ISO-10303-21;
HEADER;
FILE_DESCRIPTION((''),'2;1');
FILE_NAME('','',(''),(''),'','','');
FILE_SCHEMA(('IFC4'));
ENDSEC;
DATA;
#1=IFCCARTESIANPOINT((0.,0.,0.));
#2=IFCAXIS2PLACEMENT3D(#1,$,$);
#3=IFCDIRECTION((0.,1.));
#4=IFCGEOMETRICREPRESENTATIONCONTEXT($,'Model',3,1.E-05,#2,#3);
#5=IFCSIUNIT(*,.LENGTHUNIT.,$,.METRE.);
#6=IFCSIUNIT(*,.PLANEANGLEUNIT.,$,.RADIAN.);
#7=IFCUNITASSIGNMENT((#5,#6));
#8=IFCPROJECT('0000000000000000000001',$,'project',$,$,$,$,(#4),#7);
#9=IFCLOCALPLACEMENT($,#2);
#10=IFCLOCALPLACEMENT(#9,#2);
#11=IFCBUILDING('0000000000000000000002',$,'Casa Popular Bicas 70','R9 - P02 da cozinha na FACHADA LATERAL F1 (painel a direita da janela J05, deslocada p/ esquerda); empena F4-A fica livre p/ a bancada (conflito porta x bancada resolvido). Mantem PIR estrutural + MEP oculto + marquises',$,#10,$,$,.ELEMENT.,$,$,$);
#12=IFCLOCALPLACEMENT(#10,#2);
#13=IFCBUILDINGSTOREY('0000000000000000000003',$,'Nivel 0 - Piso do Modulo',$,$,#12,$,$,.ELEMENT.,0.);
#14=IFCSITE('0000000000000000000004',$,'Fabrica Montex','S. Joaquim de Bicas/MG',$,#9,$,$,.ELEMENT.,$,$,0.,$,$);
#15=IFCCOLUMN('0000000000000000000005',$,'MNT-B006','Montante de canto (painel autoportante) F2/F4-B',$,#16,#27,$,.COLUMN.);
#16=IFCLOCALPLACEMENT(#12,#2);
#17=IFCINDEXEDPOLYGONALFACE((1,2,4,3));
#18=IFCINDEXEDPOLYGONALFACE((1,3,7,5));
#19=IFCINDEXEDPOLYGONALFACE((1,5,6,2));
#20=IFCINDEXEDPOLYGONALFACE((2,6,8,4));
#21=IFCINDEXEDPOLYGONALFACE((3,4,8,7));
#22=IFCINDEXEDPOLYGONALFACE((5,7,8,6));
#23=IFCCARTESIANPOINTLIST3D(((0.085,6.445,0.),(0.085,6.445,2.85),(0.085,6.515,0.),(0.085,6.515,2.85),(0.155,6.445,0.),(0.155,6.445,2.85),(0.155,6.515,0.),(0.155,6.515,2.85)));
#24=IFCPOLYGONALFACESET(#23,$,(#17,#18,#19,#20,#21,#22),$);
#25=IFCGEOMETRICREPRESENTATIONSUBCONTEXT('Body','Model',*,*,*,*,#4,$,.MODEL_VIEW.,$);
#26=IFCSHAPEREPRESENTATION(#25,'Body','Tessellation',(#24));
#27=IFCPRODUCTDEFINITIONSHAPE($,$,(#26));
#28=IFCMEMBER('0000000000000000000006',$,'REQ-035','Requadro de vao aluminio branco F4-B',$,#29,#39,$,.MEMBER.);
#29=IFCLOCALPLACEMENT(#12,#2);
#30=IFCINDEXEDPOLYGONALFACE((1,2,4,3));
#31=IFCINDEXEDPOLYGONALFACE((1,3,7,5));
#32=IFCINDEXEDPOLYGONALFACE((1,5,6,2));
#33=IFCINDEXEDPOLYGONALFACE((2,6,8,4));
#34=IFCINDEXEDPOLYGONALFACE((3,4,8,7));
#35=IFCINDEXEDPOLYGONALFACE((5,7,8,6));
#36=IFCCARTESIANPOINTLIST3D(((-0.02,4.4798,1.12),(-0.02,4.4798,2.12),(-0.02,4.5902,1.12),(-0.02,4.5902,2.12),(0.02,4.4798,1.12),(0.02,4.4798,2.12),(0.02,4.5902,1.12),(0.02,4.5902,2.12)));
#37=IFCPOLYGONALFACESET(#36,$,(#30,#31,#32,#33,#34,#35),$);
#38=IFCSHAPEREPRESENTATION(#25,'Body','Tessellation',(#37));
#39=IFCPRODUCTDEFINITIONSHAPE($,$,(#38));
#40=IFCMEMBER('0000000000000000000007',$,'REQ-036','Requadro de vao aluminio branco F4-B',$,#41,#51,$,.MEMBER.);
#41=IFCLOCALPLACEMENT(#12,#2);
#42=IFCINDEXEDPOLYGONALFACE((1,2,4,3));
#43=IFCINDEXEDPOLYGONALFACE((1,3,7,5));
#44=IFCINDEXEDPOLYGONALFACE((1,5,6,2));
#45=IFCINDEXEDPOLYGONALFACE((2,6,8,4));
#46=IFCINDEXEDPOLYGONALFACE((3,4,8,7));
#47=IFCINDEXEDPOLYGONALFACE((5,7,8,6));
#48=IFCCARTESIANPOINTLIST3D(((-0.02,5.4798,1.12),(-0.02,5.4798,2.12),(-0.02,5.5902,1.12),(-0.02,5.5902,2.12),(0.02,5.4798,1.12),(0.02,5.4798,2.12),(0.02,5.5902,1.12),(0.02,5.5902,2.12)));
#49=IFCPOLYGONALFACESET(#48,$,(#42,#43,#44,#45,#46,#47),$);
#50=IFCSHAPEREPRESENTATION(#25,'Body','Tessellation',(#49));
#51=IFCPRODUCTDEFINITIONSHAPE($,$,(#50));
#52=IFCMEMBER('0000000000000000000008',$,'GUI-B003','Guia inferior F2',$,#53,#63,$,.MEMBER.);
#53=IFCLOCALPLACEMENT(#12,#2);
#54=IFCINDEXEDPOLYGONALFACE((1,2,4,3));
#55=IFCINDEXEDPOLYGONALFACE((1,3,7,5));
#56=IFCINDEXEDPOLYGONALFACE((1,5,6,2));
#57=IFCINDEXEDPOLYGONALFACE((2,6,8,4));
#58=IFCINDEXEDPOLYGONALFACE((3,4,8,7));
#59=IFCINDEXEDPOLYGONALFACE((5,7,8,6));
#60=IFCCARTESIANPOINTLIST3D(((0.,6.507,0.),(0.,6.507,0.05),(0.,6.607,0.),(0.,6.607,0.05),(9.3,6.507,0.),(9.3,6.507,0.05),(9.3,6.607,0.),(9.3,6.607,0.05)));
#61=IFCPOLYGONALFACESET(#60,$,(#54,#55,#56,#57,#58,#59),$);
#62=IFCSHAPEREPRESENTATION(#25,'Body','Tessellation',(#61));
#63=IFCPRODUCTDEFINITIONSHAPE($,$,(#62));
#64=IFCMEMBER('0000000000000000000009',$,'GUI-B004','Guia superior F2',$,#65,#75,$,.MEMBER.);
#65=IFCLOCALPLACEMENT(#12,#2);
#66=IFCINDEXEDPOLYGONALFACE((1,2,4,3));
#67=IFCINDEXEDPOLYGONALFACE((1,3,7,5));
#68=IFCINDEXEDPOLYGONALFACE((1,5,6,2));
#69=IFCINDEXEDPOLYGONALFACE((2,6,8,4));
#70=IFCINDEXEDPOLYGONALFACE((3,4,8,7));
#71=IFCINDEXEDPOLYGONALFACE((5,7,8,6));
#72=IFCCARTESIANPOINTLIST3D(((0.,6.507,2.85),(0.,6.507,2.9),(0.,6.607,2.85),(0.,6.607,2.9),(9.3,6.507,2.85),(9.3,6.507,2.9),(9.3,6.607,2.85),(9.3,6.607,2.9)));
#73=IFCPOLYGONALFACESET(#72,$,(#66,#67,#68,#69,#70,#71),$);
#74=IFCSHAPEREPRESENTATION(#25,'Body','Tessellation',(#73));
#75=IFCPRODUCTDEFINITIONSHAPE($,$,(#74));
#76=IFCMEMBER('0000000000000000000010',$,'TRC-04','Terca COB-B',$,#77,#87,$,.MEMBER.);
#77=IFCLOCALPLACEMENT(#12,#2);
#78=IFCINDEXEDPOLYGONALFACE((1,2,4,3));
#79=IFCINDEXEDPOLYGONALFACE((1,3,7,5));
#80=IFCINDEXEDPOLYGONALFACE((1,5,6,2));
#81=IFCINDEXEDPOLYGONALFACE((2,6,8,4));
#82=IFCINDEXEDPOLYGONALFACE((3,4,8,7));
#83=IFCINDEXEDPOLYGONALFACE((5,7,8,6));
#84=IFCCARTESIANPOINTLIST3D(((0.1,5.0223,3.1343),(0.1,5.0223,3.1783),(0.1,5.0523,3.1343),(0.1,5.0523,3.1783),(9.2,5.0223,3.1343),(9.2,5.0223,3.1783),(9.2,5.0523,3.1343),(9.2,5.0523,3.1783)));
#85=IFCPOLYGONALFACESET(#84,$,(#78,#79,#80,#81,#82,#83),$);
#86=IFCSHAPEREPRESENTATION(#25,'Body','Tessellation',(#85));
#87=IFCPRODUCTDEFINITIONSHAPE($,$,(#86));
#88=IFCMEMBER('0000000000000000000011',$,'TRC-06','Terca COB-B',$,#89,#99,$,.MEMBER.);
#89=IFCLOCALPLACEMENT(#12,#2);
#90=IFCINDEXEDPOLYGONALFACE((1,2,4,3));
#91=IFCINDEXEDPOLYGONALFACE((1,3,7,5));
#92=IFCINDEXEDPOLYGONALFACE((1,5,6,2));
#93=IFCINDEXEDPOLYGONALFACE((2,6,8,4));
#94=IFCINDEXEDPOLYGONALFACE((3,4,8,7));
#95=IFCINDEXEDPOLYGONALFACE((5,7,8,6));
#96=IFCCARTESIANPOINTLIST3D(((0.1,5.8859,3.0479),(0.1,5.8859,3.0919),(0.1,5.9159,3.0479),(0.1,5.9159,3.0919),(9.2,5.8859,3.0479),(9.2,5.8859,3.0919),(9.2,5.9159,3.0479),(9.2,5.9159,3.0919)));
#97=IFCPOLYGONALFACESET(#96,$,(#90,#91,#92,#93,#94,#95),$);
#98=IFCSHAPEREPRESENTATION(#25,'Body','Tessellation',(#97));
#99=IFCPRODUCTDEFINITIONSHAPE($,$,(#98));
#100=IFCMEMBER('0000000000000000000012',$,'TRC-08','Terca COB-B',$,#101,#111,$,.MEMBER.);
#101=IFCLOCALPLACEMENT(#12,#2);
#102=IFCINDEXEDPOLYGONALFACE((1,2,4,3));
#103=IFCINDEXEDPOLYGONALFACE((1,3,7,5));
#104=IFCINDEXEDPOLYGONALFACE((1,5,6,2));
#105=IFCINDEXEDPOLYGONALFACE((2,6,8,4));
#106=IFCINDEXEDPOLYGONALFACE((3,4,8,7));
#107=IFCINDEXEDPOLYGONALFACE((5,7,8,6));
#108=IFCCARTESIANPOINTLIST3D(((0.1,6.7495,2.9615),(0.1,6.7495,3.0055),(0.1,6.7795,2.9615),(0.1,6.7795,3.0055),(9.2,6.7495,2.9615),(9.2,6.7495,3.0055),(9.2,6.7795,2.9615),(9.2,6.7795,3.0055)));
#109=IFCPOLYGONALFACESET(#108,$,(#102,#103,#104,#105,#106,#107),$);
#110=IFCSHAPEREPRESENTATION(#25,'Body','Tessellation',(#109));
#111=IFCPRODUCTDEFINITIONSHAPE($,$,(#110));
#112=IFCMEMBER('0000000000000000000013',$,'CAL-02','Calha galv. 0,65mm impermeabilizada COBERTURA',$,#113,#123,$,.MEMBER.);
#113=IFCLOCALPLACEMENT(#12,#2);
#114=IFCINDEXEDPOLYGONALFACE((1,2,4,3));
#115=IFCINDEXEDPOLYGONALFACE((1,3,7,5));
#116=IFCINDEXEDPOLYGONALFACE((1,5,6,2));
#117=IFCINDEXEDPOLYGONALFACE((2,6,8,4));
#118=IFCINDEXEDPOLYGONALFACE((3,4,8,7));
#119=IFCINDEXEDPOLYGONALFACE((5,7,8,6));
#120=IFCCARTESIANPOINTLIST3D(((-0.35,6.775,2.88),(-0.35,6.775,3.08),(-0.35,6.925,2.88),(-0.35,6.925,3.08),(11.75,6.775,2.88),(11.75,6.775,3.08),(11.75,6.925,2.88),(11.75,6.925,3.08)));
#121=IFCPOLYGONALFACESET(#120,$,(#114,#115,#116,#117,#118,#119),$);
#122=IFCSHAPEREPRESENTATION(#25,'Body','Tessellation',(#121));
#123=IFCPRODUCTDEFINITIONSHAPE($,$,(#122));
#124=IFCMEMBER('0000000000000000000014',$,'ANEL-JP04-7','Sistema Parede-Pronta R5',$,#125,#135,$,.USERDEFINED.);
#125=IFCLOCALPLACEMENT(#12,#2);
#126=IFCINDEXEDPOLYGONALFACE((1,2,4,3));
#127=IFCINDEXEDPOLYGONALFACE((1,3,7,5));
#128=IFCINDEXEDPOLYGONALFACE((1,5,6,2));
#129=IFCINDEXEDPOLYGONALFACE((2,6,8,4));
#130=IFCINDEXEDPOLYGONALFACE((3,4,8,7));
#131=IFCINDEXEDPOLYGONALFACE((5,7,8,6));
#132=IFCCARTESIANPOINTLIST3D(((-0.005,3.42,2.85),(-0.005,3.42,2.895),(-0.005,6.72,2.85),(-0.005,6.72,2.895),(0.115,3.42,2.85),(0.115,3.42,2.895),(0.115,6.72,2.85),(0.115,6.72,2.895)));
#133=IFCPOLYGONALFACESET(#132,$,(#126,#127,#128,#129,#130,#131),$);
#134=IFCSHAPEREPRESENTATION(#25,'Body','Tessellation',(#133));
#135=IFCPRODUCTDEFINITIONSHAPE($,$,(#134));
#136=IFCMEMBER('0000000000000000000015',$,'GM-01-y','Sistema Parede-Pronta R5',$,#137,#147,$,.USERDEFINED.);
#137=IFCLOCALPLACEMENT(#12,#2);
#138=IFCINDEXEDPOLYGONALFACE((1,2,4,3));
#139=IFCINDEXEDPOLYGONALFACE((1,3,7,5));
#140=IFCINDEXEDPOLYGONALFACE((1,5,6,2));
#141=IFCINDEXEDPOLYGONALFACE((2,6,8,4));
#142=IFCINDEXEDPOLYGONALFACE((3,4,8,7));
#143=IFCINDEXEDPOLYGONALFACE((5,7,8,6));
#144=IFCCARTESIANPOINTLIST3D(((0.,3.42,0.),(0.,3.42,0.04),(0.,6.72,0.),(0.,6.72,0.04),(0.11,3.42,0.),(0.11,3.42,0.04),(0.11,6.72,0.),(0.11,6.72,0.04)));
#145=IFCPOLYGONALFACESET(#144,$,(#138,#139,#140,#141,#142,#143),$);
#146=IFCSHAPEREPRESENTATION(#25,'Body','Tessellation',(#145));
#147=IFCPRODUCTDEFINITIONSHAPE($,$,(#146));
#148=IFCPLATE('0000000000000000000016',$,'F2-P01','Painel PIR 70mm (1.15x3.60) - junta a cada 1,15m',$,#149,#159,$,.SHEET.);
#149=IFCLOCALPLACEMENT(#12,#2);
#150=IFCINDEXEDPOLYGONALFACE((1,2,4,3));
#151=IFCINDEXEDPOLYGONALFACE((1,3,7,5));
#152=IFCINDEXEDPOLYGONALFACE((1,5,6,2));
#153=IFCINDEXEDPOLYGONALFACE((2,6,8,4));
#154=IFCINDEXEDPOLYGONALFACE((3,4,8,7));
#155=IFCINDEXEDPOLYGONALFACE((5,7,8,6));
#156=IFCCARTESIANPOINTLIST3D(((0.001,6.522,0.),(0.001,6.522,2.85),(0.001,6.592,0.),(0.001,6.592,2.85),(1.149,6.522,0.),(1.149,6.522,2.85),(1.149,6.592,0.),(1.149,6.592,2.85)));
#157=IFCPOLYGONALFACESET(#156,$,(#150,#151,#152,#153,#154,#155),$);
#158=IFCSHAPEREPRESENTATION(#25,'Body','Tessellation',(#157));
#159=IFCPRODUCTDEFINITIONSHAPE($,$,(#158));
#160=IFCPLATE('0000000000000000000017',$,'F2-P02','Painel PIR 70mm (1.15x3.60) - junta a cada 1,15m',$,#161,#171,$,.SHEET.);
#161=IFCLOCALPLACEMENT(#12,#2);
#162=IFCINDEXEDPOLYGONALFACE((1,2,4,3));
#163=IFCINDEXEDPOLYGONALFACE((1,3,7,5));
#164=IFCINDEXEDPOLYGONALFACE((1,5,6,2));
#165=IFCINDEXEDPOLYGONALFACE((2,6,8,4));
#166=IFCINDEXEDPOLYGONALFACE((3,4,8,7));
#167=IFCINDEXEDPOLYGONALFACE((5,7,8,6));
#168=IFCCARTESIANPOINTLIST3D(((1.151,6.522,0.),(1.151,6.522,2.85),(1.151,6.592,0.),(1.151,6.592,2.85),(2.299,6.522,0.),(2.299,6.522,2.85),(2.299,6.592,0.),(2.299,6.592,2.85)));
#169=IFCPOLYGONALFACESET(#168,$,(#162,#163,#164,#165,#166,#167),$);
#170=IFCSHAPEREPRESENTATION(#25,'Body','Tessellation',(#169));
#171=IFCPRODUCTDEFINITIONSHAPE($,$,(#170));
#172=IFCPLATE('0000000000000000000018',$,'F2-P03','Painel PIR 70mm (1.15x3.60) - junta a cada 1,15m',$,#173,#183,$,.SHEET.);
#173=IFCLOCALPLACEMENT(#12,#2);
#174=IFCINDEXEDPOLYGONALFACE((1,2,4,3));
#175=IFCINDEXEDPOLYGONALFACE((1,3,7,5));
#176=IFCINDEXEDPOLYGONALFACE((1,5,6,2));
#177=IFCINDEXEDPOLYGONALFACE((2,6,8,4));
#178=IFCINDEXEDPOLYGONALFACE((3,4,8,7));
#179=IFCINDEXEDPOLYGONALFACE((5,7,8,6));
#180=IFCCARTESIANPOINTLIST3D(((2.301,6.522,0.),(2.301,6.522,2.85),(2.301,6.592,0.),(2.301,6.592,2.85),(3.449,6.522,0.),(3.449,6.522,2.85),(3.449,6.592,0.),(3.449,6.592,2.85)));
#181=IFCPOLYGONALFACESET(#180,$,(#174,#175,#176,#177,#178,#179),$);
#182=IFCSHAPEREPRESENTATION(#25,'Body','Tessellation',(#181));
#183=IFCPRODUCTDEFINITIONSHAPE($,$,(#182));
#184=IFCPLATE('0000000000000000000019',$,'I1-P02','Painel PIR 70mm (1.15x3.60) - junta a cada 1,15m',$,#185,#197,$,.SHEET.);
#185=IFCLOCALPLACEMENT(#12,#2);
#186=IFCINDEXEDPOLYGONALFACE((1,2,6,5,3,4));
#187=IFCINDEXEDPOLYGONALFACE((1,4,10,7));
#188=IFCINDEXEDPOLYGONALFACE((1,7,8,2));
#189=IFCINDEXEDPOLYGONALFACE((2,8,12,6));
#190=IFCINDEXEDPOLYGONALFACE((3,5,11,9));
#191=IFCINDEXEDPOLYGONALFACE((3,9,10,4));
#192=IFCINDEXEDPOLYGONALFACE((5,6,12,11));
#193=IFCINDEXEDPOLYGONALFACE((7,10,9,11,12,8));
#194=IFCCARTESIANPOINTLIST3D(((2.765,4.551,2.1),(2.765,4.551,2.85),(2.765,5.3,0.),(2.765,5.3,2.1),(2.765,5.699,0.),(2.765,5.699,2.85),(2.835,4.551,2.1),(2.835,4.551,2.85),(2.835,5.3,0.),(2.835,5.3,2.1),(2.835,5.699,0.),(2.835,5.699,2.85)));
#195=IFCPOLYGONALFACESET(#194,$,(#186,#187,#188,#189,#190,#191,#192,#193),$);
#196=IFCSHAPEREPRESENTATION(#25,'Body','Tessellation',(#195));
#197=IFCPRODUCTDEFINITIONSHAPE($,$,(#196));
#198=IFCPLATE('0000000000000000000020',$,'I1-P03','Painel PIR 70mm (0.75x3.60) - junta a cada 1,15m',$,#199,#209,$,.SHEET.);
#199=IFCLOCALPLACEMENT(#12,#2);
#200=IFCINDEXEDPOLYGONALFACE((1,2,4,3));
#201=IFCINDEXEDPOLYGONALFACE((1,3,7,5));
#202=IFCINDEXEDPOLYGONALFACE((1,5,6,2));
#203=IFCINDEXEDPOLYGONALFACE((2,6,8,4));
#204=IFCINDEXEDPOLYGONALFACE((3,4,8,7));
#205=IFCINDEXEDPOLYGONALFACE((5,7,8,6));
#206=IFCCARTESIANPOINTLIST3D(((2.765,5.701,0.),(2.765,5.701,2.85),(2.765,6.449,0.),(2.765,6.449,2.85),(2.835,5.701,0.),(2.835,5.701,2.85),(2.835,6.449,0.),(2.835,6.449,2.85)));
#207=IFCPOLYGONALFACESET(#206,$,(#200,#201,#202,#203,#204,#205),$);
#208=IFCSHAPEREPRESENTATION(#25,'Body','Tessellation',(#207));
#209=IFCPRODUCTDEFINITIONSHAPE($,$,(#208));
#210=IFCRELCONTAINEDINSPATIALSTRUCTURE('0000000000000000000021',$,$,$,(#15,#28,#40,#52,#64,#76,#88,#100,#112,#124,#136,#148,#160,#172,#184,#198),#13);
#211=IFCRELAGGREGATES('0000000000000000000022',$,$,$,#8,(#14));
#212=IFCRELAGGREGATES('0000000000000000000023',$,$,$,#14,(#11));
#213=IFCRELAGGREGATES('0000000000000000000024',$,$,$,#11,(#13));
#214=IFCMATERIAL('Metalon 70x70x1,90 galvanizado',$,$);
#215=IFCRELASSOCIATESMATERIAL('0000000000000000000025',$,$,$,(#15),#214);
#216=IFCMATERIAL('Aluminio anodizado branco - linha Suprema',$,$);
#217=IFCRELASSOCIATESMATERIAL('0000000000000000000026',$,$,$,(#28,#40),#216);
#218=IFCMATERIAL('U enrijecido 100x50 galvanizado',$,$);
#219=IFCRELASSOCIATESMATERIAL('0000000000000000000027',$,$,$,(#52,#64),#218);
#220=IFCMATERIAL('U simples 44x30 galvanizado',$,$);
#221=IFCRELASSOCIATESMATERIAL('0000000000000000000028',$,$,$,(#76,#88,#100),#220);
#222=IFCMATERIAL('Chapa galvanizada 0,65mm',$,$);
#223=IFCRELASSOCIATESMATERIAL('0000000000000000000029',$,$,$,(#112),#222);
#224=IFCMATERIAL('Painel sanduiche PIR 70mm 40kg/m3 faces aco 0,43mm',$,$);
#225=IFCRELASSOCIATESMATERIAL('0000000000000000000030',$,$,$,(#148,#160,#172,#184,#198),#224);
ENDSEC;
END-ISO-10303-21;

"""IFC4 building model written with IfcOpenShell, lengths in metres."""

from ifc_helpers import new_model, si_unit, direction, frame, frame_2d, origin, origin_2d, place, context, subcontext, project, spatial, rectangle, extrude, material, element, save


model = new_model("IFC4")

# Units and contexts
model_context = context("Model", 3, precision=1e-05, world=origin(), true_north=direction((0.0, 1.0)))
body_context = subcontext(model_context, "Body", "Model", "MODEL_VIEW")
ifc_project = project(units=[si_unit("LENGTHUNIT", "METRE"), si_unit("PLANEANGLEUNIT", "RADIAN")], contexts=[model_context])

# Site, building, storey
site_placement = place(None, origin())
site = spatial("IfcSite", under=ifc_project, at=site_placement, Name="Fabrica Montex", Description="S. Joaquim de Bicas/MG", CompositionType="ELEMENT", RefElevation=0.0)
building_placement = place(site_placement, origin())
building = spatial("IfcBuilding", under=site, at=building_placement, Name="Casa Popular Bicas 70", Description="R9 - P02 da cozinha na FACHADA LATERAL F1 (painel a direita da janela J05, deslocada p/ esquerda); empena F4-A fica livre p/ a bancada (conflito porta x bancada resolvido). Mantem PIR estrutural + MEP oculto + marquises", CompositionType="ELEMENT")
storey_placement = place(building_placement, origin())
storey = spatial("IfcBuildingStorey", under=building, at=storey_placement, Name="Nivel 0 - Piso do Modulo", CompositionType="ELEMENT", Elevation=0.0)

# Column
ifc_material_1 = material(Name="Metalon 70x70x1,90 galvanizado")
column_placement = place(storey_placement, frame((0.12, 6.48, 0.0)))
element("IfcColumn", 1, at=column_placement, inside=storey, material=ifc_material_1, Name="MNT-B006", Description="Montante de canto (painel autoportante) F2/F4-B", PredefinedType="COLUMN", context=body_context, shape_type="SweptSolid", body=[
    extrude(rectangle(XDim=0.07, YDim=0.07, at=origin_2d()), origin(), (0.0, 0.0, 1.0), 2.85),
])

# Members
ifc_material_2 = material(Name="Aluminio anodizado branco - linha Suprema")
for number, where, z_axis, x_axis, name in (
    (2, (0.0, 4.535, 1.12), (0.0, 0.0, 1.0), (1.0, 0.0, 0.0), "REQ-035"),
    (3, (0.0, 5.535, 1.12), (0.0, 0.0, 1.0), (1.0, 0.0, 0.0), "REQ-036"),
):
    element("IfcMember", number, at=place(storey_placement, frame(where, z_axis=z_axis, x_axis=x_axis)), inside=storey, material=ifc_material_2, Name=name, Description="Requadro de vao aluminio branco F4-B", PredefinedType="MEMBER", context=body_context, shape_type="SweptSolid", body=[
        extrude(rectangle(XDim=0.04, YDim=0.1105, at=origin_2d()), origin(), (0.0, 0.0, 1.0), 1.0),
    ])
ifc_material_3 = material(Name="U enrijecido 100x50 galvanizado")
for number, where, z_axis, x_axis, name, description in (
    (4, (0.0, 6.557, 0.025), (1.0, 0.0, 0.0), (0.0, 0.0, 1.0), "GUI-B003", "Guia inferior F2"),
    (5, (0.0, 6.557, 2.875), (1.0, 0.0, 0.0), (0.0, 0.0, 1.0), "GUI-B004", "Guia superior F2"),
):
    element("IfcMember", number, at=place(storey_placement, frame(where, z_axis=z_axis, x_axis=x_axis)), inside=storey, material=ifc_material_3, Name=name, Description=description, PredefinedType="MEMBER", context=body_context, shape_type="SweptSolid", body=[
        extrude(rectangle(XDim=0.05, YDim=0.1, at=origin_2d()), origin(), (0.0, 0.0, 1.0), 9.3),
    ])
ifc_material_4 = material(Name="U simples 44x30 galvanizado")
for number, where, z_axis, x_axis, name in (
    (6, (0.1, 5.0373, 3.1563), (1.0, 0.0, 0.0), (0.0, 0.0, 1.0), "TRC-04"),
    (7, (0.1, 5.9009, 3.0699), (1.0, 0.0, 0.0), (0.0, 0.0, 1.0), "TRC-06"),
    (8, (0.1, 6.7645, 2.9835), (1.0, 0.0, 0.0), (0.0, 0.0, 1.0), "TRC-08"),
):
    element("IfcMember", number, at=place(storey_placement, frame(where, z_axis=z_axis, x_axis=x_axis)), inside=storey, material=ifc_material_4, Name=name, Description="Terca COB-B", PredefinedType="MEMBER", context=body_context, shape_type="SweptSolid", body=[
        extrude(rectangle(XDim=0.044, YDim=0.03, at=origin_2d()), origin(), (0.0, 0.0, 1.0), 9.1),
    ])
ifc_material_5 = material(Name="Chapa galvanizada 0,65mm")
member_1_placement = place(storey_placement, frame((-0.35, 6.85, 2.98), z_axis=(1.0, 0.0, 0.0), x_axis=(0.0, 0.0, 1.0)))
element("IfcMember", 9, at=member_1_placement, inside=storey, material=ifc_material_5, Name="CAL-02", Description="Calha galv. 0,65mm impermeabilizada COBERTURA", PredefinedType="MEMBER", context=body_context, shape_type="SweptSolid", body=[
    extrude(rectangle(XDim=0.2, YDim=0.15, at=origin_2d()), origin(), (0.0, 0.0, 1.0), 12.1),
])
member_2_placement = place(storey_placement, frame((0.055, 5.07, 2.85)))
element("IfcMember", 10, at=member_2_placement, inside=storey, Name="ANEL-JP04-7", Description="Sistema Parede-Pronta R5", PredefinedType="USERDEFINED", context=body_context, shape_type="SweptSolid", body=[
    extrude(rectangle(XDim=0.12, YDim=3.3, at=origin_2d()), origin(), (0.0, 0.0, 1.0), 0.045),
])
member_3_placement = place(storey_placement, frame((0.055, 5.07, 0.0)))
element("IfcMember", 11, at=member_3_placement, inside=storey, Name="GM-01-y", Description="Sistema Parede-Pronta R5", PredefinedType="USERDEFINED", context=body_context, shape_type="SweptSolid", body=[
    extrude(rectangle(XDim=0.11, YDim=3.3, at=origin_2d()), origin(), (0.0, 0.0, 1.0), 0.04),
])

# Plates
ifc_material_6 = material(Name="Painel sanduiche PIR 70mm 40kg/m3 faces aco 0,43mm")
for number, where, x_axis, name in (
    (12, (0.001, 6.557, 0.0), (1.0, 0.0, 0.0), "F2-P01"),
    (13, (1.151, 6.557, 0.0), (1.0, 0.0, 0.0), "F2-P02"),
    (14, (2.301, 6.557, 0.0), (1.0, 0.0, 0.0), "F2-P03"),
):
    element("IfcPlate", number, at=place(storey_placement, frame(where, x_axis=x_axis)), inside=storey, material=ifc_material_6, Name=name, Description="Painel PIR 70mm (1.15x3.60) - junta a cada 1,15m", PredefinedType="SHEET", context=body_context, shape_type="SweptSolid", body=[
        extrude(rectangle(XDim=1.148, YDim=0.07, at=frame_2d((0.574, 0.0))), origin(), (0.0, 0.0, 1.0), 2.85),
    ])

# Plate, opening
plate_1_placement = place(storey_placement, frame((2.8, 4.551, 0.0), x_axis=(0.0, 1.0, 0.0)))
plate_1 = element("IfcPlate", 15, at=plate_1_placement, inside=storey, material=ifc_material_6, Name="I1-P02", Description="Painel PIR 70mm (1.15x3.60) - junta a cada 1,15m", PredefinedType="SHEET", context=body_context, shape_type="SweptSolid", body=[
    extrude(rectangle(XDim=1.148, YDim=0.07, at=frame_2d((0.574, 0.0))), origin(), (0.0, 0.0, 1.0), 2.85),
])
opening_1_placement = place(storey_placement, frame((2.8, 4.925, 0.0)))
element("IfcOpeningElement", 16, at=opening_1_placement, cuts=plate_1, PredefinedType="OPENING", context=body_context, shape_type="SweptSolid", body=[
    extrude(rectangle(XDim=0.1, YDim=0.75, at=origin_2d()), origin(), (0.0, 0.0, 1.0), 2.1),
])

# Plate
plate_2_placement = place(storey_placement, frame((2.8, 5.701, 0.0), x_axis=(0.0, 1.0, 0.0)))
element("IfcPlate", 17, at=plate_2_placement, inside=storey, material=ifc_material_6, Name="I1-P03", Description="Painel PIR 70mm (0.75x3.60) - junta a cada 1,15m", PredefinedType="SHEET", context=body_context, shape_type="SweptSolid", body=[
    extrude(rectangle(XDim=0.748, YDim=0.07, at=frame_2d((0.374, 0.0))), origin(), (0.0, 0.0, 1.0), 2.85),
])

save(model, "model.ifc")
